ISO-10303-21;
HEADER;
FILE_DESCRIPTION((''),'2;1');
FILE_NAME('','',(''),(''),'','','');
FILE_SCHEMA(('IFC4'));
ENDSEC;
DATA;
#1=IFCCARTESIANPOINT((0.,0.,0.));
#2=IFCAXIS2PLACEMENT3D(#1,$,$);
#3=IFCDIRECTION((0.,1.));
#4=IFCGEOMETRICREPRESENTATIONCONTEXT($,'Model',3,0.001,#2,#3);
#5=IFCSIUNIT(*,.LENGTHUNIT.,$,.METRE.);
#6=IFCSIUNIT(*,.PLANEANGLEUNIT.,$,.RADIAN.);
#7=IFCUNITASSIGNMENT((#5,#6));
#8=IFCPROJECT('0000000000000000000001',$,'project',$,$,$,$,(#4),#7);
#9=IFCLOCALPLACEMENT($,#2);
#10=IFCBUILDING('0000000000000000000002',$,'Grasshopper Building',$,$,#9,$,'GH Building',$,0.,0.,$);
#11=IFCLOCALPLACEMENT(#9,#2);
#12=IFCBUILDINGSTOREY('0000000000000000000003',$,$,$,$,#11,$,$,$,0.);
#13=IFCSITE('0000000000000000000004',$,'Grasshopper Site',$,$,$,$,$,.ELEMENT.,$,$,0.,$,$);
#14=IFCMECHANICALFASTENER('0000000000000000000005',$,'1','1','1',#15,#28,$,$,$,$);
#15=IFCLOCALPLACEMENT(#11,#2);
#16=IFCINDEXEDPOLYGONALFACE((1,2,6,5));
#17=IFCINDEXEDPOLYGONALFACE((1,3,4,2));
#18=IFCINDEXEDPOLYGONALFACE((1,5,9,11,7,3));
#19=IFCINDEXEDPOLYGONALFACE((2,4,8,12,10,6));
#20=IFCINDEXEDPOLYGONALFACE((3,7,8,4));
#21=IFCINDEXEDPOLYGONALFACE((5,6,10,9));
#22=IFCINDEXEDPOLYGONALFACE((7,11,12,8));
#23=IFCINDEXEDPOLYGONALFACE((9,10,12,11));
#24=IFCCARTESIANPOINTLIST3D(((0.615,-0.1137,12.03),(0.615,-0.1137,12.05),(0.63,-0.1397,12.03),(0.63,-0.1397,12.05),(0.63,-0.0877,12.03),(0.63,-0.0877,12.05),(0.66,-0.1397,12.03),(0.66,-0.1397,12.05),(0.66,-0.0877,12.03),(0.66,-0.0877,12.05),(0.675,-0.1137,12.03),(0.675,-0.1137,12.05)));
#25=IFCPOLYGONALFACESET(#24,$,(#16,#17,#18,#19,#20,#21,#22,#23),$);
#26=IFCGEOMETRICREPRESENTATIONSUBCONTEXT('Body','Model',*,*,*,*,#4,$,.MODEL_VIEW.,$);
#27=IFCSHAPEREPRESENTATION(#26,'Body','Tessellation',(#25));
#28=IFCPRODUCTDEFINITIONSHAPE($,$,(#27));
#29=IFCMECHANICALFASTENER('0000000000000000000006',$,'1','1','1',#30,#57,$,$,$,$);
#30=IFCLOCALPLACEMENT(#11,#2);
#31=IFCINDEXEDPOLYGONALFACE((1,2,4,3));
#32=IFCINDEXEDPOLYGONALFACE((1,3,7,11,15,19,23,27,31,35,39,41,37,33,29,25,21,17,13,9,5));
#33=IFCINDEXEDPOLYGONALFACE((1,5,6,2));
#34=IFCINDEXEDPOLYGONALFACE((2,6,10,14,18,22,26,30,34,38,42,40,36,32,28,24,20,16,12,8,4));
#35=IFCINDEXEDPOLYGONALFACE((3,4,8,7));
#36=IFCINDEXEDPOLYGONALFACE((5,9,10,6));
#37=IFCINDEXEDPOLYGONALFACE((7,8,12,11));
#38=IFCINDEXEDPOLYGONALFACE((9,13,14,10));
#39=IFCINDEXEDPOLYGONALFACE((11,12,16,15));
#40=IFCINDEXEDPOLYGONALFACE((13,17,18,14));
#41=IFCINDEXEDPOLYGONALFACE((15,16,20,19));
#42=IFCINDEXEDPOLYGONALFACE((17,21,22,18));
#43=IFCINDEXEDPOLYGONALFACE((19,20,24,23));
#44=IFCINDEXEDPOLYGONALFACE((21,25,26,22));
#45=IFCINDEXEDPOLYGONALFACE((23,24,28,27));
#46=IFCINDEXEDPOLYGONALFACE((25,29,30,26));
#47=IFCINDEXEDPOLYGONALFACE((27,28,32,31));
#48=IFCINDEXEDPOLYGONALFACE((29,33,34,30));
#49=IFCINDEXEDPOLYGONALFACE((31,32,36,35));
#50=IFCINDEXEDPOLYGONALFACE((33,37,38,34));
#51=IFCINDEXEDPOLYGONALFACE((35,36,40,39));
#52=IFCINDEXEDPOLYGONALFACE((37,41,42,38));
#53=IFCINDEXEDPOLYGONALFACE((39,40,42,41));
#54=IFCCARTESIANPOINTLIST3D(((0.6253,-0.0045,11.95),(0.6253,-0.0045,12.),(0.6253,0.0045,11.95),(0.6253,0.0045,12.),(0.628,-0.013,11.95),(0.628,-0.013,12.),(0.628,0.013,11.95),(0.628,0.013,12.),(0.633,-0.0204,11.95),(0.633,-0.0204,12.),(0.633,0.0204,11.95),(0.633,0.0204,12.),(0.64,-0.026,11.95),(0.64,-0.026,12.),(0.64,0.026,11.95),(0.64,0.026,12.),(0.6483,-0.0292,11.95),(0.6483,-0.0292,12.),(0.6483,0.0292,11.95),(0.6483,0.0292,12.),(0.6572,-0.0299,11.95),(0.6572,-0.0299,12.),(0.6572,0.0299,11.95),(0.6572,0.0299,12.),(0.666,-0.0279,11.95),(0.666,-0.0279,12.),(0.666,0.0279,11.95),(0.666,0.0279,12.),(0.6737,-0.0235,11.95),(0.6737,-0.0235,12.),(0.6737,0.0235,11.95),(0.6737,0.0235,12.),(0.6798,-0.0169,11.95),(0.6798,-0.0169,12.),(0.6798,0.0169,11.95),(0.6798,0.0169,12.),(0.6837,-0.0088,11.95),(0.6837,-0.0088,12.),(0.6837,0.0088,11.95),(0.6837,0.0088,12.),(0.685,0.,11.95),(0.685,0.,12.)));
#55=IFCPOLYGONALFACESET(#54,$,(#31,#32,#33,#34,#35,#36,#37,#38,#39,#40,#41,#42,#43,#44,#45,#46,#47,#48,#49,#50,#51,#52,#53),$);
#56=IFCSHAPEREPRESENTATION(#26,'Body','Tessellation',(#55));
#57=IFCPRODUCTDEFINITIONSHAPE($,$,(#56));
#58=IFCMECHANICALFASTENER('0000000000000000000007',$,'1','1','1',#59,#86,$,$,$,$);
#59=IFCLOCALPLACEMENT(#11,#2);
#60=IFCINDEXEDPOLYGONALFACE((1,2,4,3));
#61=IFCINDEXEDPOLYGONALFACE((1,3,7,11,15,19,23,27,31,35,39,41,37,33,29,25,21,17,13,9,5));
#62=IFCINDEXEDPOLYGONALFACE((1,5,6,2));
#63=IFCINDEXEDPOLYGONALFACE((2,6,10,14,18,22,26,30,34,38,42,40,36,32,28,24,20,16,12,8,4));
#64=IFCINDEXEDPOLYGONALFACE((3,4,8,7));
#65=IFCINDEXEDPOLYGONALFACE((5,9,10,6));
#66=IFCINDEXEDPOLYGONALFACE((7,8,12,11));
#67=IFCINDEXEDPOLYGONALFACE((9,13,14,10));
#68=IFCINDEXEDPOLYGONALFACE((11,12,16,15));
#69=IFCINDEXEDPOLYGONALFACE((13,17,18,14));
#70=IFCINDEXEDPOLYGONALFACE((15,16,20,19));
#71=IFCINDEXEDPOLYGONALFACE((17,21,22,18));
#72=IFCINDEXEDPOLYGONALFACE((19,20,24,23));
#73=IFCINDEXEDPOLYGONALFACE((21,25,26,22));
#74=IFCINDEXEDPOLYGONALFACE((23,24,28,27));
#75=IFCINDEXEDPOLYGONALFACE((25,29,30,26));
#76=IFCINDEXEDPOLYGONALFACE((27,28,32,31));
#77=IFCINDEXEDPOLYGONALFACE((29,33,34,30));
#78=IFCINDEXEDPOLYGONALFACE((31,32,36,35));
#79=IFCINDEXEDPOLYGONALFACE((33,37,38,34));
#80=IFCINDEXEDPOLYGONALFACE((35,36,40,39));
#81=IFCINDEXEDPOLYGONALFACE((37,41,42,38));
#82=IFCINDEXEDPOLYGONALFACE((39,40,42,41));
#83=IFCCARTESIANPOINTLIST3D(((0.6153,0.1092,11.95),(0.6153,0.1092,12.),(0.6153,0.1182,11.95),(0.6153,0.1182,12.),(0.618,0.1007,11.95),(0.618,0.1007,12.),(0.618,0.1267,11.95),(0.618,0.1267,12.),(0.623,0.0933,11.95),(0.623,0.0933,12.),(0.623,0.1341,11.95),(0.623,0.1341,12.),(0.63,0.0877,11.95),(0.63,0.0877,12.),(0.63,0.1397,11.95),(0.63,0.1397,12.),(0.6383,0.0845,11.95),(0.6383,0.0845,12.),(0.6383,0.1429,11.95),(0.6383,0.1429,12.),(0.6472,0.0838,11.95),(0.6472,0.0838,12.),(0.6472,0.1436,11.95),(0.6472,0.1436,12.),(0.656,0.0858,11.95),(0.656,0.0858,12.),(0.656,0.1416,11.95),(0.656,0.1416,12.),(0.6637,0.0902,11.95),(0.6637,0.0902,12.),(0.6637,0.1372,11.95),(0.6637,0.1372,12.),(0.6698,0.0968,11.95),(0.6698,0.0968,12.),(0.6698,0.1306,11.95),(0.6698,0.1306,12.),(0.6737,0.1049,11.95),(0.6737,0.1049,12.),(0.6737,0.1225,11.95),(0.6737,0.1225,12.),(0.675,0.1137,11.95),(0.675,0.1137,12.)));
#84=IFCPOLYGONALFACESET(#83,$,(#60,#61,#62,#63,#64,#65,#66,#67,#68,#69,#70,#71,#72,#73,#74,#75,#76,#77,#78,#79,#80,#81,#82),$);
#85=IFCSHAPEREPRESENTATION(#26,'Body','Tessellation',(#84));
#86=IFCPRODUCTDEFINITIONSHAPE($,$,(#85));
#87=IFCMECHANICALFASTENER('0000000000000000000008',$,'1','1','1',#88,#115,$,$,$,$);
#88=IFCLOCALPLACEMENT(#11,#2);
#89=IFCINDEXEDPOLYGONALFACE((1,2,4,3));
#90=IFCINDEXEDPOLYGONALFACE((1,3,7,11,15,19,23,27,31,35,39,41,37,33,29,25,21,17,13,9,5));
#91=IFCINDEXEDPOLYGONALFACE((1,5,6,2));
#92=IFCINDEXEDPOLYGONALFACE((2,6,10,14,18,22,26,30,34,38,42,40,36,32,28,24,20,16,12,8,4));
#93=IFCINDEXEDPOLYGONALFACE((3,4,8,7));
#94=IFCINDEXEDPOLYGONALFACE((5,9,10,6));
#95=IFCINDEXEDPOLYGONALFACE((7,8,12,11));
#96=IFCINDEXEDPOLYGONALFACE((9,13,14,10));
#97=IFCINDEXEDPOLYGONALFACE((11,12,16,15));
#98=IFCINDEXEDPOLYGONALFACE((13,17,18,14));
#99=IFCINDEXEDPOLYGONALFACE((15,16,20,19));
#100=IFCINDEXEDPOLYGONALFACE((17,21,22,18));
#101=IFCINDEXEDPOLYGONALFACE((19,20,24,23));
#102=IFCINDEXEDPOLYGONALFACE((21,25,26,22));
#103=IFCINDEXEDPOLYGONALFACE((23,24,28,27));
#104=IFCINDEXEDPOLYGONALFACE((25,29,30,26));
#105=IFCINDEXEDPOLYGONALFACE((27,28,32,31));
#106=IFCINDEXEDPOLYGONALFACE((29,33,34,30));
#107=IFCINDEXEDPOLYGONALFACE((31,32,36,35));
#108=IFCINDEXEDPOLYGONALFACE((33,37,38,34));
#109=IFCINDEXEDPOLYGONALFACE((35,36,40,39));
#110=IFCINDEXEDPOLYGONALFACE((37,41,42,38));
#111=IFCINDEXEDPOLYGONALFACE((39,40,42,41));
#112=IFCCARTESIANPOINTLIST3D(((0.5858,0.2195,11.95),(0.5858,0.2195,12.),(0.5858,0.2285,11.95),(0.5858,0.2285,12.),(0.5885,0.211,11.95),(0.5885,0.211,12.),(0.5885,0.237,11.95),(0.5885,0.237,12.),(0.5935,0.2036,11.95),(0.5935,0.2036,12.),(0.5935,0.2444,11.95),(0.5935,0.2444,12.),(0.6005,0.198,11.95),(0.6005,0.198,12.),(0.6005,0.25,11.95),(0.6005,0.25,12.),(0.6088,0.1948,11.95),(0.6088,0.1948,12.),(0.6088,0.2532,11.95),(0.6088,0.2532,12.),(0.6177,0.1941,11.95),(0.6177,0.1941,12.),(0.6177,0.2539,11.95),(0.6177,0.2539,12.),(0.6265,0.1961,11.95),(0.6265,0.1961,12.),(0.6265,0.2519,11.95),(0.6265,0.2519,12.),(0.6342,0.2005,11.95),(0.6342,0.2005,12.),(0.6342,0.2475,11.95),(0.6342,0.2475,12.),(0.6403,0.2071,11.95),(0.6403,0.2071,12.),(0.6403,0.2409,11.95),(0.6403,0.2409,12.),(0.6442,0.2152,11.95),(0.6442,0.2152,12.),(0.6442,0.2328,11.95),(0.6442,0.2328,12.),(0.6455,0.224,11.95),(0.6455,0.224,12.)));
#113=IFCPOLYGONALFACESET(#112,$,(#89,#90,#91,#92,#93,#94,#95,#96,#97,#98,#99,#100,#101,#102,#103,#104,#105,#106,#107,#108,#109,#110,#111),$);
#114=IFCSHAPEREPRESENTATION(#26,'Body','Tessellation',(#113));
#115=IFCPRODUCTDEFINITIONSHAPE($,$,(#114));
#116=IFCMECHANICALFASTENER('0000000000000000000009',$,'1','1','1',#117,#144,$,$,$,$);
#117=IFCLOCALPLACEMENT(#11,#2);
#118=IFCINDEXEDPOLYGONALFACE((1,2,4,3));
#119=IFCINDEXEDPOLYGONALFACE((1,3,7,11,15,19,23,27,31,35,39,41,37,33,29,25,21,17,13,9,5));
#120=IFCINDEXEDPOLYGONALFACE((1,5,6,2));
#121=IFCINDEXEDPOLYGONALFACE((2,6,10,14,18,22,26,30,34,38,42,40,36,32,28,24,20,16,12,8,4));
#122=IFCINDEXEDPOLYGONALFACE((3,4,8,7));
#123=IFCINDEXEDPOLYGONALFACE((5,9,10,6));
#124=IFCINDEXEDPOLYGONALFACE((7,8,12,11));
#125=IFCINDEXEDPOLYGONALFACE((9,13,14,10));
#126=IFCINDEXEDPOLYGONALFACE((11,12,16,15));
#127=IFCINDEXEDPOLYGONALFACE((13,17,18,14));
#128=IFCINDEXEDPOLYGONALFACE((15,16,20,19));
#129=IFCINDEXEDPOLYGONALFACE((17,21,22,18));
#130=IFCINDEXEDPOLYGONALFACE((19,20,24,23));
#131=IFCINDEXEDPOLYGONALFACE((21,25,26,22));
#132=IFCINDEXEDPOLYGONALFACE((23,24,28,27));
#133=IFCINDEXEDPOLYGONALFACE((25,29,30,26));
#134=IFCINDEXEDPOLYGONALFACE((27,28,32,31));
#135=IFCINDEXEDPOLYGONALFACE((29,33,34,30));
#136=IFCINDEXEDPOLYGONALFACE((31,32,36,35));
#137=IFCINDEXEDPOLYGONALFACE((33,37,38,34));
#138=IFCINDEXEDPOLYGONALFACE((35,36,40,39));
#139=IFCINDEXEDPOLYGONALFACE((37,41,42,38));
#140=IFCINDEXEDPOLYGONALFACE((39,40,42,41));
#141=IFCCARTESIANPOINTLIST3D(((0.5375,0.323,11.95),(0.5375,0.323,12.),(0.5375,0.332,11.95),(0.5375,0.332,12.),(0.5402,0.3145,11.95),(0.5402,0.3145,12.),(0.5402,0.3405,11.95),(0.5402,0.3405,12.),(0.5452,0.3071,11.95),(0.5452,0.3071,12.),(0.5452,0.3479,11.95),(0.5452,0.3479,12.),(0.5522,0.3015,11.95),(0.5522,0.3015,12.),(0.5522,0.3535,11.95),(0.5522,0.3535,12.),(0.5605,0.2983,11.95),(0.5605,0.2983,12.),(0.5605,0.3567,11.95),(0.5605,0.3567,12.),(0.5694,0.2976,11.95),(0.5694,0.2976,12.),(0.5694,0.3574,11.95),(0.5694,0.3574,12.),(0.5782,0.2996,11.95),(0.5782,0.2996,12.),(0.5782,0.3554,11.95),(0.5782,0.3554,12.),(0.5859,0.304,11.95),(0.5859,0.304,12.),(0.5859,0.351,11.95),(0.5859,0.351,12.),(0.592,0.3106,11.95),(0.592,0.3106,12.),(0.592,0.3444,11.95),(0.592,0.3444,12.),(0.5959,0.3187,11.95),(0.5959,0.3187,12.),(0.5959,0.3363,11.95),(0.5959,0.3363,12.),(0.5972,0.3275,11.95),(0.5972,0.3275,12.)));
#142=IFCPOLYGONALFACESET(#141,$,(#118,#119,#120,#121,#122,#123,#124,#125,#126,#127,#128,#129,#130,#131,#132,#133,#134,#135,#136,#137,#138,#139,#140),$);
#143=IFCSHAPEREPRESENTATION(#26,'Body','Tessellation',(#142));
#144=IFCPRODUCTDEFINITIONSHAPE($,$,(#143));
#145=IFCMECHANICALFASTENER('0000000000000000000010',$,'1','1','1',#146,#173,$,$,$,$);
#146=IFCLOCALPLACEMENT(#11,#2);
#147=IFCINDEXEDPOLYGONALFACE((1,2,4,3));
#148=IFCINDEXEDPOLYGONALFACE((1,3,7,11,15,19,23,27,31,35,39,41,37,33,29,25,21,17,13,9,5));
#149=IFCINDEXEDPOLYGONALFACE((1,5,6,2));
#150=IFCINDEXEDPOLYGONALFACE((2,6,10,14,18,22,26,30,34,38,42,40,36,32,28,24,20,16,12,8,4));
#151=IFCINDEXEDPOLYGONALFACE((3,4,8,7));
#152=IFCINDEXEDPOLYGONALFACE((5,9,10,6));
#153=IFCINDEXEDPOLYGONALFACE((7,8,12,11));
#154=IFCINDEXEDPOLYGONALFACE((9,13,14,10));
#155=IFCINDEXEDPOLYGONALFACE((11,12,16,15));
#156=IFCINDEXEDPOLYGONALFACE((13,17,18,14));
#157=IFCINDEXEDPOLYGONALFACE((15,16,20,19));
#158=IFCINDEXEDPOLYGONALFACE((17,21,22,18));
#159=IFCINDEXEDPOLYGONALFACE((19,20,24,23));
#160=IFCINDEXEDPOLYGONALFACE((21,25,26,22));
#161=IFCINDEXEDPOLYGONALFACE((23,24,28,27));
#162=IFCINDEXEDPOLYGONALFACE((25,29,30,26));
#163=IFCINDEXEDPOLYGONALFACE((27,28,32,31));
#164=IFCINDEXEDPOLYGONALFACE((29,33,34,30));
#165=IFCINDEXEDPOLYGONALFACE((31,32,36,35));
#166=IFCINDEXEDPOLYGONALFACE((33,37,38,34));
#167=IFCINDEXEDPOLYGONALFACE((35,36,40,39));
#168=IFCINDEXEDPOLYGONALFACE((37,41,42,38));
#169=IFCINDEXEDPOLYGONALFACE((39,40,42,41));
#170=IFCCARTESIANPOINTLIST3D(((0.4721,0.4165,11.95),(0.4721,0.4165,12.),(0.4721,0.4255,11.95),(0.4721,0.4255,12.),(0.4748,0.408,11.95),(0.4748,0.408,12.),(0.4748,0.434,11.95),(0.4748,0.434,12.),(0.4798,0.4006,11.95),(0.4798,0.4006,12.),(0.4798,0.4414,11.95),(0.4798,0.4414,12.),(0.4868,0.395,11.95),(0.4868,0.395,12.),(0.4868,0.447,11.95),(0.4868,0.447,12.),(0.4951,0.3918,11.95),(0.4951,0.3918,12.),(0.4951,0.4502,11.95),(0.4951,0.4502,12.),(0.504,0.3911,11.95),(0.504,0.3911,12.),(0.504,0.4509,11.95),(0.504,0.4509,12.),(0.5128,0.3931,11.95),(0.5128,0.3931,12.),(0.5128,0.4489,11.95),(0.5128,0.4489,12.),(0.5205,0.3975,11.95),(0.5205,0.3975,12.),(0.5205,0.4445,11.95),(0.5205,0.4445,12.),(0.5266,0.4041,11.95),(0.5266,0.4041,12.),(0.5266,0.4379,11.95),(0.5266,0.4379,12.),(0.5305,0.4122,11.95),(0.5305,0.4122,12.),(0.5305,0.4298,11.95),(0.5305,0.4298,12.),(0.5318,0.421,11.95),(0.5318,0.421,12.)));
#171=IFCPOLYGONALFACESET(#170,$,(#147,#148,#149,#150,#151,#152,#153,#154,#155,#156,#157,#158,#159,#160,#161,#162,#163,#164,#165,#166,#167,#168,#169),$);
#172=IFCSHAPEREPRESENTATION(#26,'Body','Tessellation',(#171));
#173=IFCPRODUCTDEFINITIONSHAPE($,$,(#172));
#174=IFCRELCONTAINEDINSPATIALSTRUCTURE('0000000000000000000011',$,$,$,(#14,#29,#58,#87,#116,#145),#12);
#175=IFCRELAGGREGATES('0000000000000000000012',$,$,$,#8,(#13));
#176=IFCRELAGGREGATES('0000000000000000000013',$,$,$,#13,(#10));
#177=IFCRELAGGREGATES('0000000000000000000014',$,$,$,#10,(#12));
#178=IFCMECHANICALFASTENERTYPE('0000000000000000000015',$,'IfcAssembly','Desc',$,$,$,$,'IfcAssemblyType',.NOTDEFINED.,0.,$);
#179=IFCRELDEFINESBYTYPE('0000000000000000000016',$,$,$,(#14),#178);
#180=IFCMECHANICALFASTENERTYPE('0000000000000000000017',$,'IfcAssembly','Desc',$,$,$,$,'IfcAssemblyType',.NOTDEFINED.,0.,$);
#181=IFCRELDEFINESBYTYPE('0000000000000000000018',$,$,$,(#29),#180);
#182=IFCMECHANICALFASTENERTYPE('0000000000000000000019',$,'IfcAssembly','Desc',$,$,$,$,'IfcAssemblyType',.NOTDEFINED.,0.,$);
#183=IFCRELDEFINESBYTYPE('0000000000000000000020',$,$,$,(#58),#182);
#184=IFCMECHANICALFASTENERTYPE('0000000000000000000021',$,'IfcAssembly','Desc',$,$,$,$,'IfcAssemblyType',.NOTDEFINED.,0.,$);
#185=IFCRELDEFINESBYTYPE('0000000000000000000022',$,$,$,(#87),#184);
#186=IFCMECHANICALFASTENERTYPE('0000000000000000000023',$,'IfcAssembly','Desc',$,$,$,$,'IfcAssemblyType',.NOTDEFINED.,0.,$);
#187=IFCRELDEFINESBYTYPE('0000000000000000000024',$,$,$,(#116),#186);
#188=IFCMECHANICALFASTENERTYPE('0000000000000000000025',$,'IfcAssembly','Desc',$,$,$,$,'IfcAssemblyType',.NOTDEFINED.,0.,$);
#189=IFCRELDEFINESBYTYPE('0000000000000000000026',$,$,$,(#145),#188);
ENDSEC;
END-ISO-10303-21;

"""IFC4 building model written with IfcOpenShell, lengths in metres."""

from ifc_helpers import new_model, si_unit, direction, frame, origin, place, context, subcontext, project, spatial, indexed_curve, circle, outline, extrude, source, transform, mapped, type_object, type_shapes, element, save


model = new_model("IFC4")

# Units and contexts
model_context = context("Model", 3, precision=0.001, world=origin(), true_north=direction((0.0, 1.0)))
body_context = subcontext(model_context, "Body", "Model", "MODEL_VIEW")
ifc_project = project(units=[si_unit("LENGTHUNIT", "METRE"), si_unit("PLANEANGLEUNIT", "RADIAN")], contexts=[model_context])

# Site, building, storey
site = spatial("IfcSite", under=ifc_project, Name="Grasshopper Site", CompositionType="ELEMENT", RefElevation=0.0)
building_placement = place(None, origin())
building = spatial("IfcBuilding", under=site, at=building_placement, Name="Grasshopper Building", LongName="GH Building", ElevationOfRefHeight=0.0, ElevationOfTerrain=0.0)
storey_placement = place(building_placement, origin())
storey = spatial("IfcBuildingStorey", under=building, at=storey_placement, Elevation=0.0)

# Mechanical fasteners
mechanical_fastener_type_1 = type_object("IfcMechanicalFastenerType", Name="IfcAssembly", Description="Desc", ElementType="IfcAssemblyType", NominalDiameter=0.0)
shared_shape_1 = source(origin(), body_context, "Body", "SweptSolid", [
    extrude(outline(indexed_curve([(0.03, 0.0), (0.015, 0.026), (-0.015, 0.026), (-0.03, 0.0), (-0.015, -0.026), (0.015, -0.026), (0.03, 0.0)])), frame((0.645, -0.1137, 12.03)), (0.0, 0.0, 1.0), 0.02),
])
type_shapes(mechanical_fastener_type_1, [shared_shape_1])
mechanical_fastener_1_placement = place(storey_placement, origin())
element("IfcMechanicalFastener", 1, at=mechanical_fastener_1_placement, inside=storey, type_object=mechanical_fastener_type_1, Name="1", Description="1", ObjectType="1", context=body_context, shape_type="MappedRepresentation", body=[
    mapped(shared_shape_1, transform((0.0, 0.0, 0.0), scale=1.0)),
])
mechanical_fastener_type_2 = type_object("IfcMechanicalFastenerType", Name="IfcAssembly", Description="Desc", ElementType="IfcAssemblyType", NominalDiameter=0.0)
shared_shape_2 = source(origin(), body_context, "Body", "SweptSolid", [
    extrude(circle(Radius=0.03), frame((0.655, 0.0, 12.0), z_axis=(0.0, 0.0, -1.0), x_axis=(1.0, 0.0, 0.0)), (0.0, 0.0, 1.0), 0.05),
])
type_shapes(mechanical_fastener_type_2, [shared_shape_2])
mechanical_fastener_2_placement = place(storey_placement, origin())
element("IfcMechanicalFastener", 2, at=mechanical_fastener_2_placement, inside=storey, type_object=mechanical_fastener_type_2, Name="1", Description="1", ObjectType="1", context=body_context, shape_type="MappedRepresentation", body=[
    mapped(shared_shape_2, transform((0.0, 0.0, 0.0), scale=1.0)),
])
mechanical_fastener_type_3 = type_object("IfcMechanicalFastenerType", Name="IfcAssembly", Description="Desc", ElementType="IfcAssemblyType", NominalDiameter=0.0)
shared_shape_3 = source(origin(), body_context, "Body", "SweptSolid", [
    extrude(circle(Radius=0.03), frame((0.645, 0.1137, 12.0), z_axis=(0.0, 0.0, -1.0), x_axis=(1.0, 0.0, 0.0)), (0.0, 0.0, 1.0), 0.05),
])
type_shapes(mechanical_fastener_type_3, [shared_shape_3])
mechanical_fastener_3_placement = place(storey_placement, origin())
element("IfcMechanicalFastener", 3, at=mechanical_fastener_3_placement, inside=storey, type_object=mechanical_fastener_type_3, Name="1", Description="1", ObjectType="1", context=body_context, shape_type="MappedRepresentation", body=[
    mapped(shared_shape_3, transform((0.0, 0.0, 0.0), scale=1.0)),
])
mechanical_fastener_type_4 = type_object("IfcMechanicalFastenerType", Name="IfcAssembly", Description="Desc", ElementType="IfcAssemblyType", NominalDiameter=0.0)
shared_shape_4 = source(origin(), body_context, "Body", "SweptSolid", [
    extrude(circle(Radius=0.03), frame((0.6155, 0.224, 12.0), z_axis=(0.0, 0.0, -1.0), x_axis=(1.0, 0.0, 0.0)), (0.0, 0.0, 1.0), 0.05),
])
type_shapes(mechanical_fastener_type_4, [shared_shape_4])
mechanical_fastener_4_placement = place(storey_placement, origin())
element("IfcMechanicalFastener", 4, at=mechanical_fastener_4_placement, inside=storey, type_object=mechanical_fastener_type_4, Name="1", Description="1", ObjectType="1", context=body_context, shape_type="MappedRepresentation", body=[
    mapped(shared_shape_4, transform((0.0, 0.0, 0.0), scale=1.0)),
])
mechanical_fastener_type_5 = type_object("IfcMechanicalFastenerType", Name="IfcAssembly", Description="Desc", ElementType="IfcAssemblyType", NominalDiameter=0.0)
shared_shape_5 = source(origin(), body_context, "Body", "SweptSolid", [
    extrude(circle(Radius=0.03), frame((0.5672, 0.3275, 12.0), z_axis=(0.0, 0.0, -1.0), x_axis=(1.0, 0.0, 0.0)), (0.0, 0.0, 1.0), 0.05),
])
type_shapes(mechanical_fastener_type_5, [shared_shape_5])
mechanical_fastener_5_placement = place(storey_placement, origin())
element("IfcMechanicalFastener", 5, at=mechanical_fastener_5_placement, inside=storey, type_object=mechanical_fastener_type_5, Name="1", Description="1", ObjectType="1", context=body_context, shape_type="MappedRepresentation", body=[
    mapped(shared_shape_5, transform((0.0, 0.0, 0.0), scale=1.0)),
])
mechanical_fastener_type_6 = type_object("IfcMechanicalFastenerType", Name="IfcAssembly", Description="Desc", ElementType="IfcAssemblyType", NominalDiameter=0.0)
shared_shape_6 = source(origin(), body_context, "Body", "SweptSolid", [
    extrude(circle(Radius=0.03), frame((0.5018, 0.421, 12.0), z_axis=(0.0, 0.0, -1.0), x_axis=(1.0, 0.0, 0.0)), (0.0, 0.0, 1.0), 0.05),
])
type_shapes(mechanical_fastener_type_6, [shared_shape_6])
mechanical_fastener_6_placement = place(storey_placement, origin())
element("IfcMechanicalFastener", 6, at=mechanical_fastener_6_placement, inside=storey, type_object=mechanical_fastener_type_6, Name="1", Description="1", ObjectType="1", context=body_context, shape_type="MappedRepresentation", body=[
    mapped(shared_shape_6, transform((0.0, 0.0, 0.0), scale=1.0)),
])

save(model, "model.ifc")
